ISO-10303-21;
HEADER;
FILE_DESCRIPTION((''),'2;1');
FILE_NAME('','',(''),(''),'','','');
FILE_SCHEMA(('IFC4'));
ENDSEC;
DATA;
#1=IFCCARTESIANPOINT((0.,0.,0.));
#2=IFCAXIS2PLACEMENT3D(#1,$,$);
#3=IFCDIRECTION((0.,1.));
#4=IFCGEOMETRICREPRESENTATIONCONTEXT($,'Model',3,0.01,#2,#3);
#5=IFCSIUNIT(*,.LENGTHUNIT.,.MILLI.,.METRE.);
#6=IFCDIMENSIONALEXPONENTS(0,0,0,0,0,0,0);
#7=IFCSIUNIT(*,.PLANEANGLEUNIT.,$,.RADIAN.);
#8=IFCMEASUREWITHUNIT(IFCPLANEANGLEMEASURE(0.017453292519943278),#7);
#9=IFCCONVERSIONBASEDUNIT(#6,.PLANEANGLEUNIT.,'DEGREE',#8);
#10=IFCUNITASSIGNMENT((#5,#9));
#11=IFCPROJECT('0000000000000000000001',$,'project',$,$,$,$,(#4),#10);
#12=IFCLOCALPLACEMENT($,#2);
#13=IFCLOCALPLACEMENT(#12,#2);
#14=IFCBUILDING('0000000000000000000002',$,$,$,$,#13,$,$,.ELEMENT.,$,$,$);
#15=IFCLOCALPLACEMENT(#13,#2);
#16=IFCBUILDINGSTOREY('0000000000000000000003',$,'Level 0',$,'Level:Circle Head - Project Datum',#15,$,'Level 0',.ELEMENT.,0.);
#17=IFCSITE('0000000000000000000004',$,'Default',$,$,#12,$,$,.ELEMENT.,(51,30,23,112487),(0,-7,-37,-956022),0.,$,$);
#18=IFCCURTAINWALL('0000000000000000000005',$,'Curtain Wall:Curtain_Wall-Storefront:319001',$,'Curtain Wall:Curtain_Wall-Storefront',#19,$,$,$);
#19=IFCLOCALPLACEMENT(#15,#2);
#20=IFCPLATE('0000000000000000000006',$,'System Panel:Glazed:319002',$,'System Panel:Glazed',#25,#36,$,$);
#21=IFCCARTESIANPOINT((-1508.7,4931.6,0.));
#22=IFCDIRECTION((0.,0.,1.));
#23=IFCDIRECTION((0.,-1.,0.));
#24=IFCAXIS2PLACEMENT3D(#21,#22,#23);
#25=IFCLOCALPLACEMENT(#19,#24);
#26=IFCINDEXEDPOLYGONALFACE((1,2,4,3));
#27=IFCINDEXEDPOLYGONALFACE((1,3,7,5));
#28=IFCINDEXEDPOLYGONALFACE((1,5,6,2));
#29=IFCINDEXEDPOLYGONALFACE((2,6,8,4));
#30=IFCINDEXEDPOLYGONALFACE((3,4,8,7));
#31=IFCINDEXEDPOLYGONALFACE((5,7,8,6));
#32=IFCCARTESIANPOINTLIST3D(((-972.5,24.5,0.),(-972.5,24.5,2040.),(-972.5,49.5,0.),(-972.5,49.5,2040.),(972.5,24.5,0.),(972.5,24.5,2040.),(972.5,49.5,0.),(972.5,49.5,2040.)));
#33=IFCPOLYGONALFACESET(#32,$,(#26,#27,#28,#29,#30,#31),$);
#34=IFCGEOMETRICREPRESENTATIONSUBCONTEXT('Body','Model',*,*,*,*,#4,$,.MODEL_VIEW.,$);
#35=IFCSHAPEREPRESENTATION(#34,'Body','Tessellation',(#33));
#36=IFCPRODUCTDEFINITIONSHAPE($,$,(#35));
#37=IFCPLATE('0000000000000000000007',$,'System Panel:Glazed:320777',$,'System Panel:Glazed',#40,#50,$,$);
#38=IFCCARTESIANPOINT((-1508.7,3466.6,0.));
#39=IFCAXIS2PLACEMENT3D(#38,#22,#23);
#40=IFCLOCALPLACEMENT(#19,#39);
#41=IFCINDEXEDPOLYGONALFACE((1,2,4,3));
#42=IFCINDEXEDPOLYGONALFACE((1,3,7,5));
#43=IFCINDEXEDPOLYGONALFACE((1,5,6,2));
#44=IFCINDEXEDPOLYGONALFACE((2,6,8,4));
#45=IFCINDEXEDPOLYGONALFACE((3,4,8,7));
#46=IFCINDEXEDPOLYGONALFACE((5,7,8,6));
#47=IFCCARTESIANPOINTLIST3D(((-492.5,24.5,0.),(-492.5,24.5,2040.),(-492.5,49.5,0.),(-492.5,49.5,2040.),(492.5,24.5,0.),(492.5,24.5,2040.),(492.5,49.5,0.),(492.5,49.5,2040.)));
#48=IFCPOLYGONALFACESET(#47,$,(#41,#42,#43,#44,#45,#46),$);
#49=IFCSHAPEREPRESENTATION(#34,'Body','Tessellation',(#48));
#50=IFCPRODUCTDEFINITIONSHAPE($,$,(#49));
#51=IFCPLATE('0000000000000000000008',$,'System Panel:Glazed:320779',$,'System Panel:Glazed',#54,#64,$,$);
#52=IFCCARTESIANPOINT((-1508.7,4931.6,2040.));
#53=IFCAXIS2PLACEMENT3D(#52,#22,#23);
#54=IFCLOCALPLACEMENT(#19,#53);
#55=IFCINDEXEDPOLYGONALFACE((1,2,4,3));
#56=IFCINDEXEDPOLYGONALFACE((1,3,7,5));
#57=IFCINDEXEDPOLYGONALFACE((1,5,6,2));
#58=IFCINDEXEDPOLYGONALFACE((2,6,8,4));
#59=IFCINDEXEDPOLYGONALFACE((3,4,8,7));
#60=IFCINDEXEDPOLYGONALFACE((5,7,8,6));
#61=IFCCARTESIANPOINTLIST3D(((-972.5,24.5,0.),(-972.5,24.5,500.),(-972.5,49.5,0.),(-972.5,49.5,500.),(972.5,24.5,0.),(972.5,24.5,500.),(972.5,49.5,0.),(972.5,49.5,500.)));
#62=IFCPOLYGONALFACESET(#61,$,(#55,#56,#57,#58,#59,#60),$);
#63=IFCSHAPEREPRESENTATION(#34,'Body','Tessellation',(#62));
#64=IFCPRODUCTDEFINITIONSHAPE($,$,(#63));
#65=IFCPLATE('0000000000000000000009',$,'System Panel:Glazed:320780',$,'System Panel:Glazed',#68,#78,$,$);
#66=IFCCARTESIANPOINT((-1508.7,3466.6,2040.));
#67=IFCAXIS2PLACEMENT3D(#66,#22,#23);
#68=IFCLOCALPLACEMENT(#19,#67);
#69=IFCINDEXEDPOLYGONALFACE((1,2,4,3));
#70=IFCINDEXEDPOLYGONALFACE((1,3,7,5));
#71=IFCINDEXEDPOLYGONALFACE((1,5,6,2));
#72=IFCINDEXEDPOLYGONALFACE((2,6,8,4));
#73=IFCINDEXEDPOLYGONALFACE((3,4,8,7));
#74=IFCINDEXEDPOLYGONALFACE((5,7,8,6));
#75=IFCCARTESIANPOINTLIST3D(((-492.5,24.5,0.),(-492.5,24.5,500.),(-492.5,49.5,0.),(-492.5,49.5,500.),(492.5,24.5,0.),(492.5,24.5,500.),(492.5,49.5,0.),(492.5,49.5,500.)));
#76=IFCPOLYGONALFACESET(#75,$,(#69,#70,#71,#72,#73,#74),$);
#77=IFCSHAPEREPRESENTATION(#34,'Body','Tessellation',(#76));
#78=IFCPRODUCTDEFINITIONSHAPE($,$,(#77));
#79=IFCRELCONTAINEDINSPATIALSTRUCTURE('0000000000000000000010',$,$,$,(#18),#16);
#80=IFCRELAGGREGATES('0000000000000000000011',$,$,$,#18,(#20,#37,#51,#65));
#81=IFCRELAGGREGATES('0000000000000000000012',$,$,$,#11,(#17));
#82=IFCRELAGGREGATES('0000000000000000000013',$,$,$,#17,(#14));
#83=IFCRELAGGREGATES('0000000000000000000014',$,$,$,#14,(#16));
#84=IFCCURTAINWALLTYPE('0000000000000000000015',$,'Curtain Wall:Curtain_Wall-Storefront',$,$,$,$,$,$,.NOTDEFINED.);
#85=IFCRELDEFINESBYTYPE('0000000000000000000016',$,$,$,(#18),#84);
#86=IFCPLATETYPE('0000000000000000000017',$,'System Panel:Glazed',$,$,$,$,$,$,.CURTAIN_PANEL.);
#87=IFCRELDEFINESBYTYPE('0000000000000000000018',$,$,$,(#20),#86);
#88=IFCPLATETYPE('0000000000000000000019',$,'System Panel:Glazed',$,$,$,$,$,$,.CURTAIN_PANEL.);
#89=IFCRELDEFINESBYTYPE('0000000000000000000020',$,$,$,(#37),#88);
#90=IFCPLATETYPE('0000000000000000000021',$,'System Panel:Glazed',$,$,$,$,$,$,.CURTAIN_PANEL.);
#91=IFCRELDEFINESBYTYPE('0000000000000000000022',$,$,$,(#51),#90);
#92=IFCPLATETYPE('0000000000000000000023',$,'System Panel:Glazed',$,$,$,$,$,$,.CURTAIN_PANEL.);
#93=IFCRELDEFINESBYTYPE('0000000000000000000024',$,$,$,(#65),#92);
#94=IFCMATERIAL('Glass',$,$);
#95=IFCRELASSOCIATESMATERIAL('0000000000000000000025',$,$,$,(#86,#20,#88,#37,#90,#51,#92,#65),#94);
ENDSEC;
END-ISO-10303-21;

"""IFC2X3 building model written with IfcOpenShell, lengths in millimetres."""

from ifc_helpers import new_model, entity, si_unit, converted_unit, direction, frame, origin, origin_2d_with_axis, place, context, subcontext, project, spatial, rectangle, extrude, source, transform, mapped, material, type_object, type_shapes, element, aggregate, save


model = new_model("IFC2X3")

# Units and contexts
model_context = context("Model", 3, precision=0.01, world=origin(), true_north=direction((0.0, 1.0)))
body_context = subcontext(model_context, "Body", "Model", "MODEL_VIEW")
ifc_project = project(units=[si_unit("LENGTHUNIT", "METRE", prefix="MILLI"), converted_unit("PLANEANGLEUNIT", "DEGREE", entity("IfcPlaneAngleMeasure", 0.017453292519943278), si_unit("PLANEANGLEUNIT", "RADIAN"), dimensions=[0, 0, 0, 0, 0, 0, 0])], contexts=[model_context])

# Site, building, storey
site_placement = place(None, origin())
site = spatial("IfcSite", under=ifc_project, at=site_placement, Name="Default", CompositionType="ELEMENT", RefLatitude=(51, 30, 23, 112487), RefLongitude=(0, -7, -37, -956022), RefElevation=0.0)
building_placement = place(site_placement, origin())
building = spatial("IfcBuilding", under=site, at=building_placement, CompositionType="ELEMENT")
storey_placement = place(building_placement, origin())
storey = spatial("IfcBuildingStorey", under=building, at=storey_placement, Name="Level 0", ObjectType="Level:Circle Head - Project Datum", LongName="Level 0", CompositionType="ELEMENT", Elevation=0.0)

# Curtain wall, plates
curtain_wall_type = type_object("IfcCurtainWallType", Name="Curtain Wall:Curtain_Wall-Storefront", PredefinedType="NOTDEFINED")
ifc_material_1 = material(Name="Glass")
curtain_wall_1_placement = place(storey_placement, origin())
curtain_wall_1 = element("IfcCurtainWall", 1, at=curtain_wall_1_placement, inside=storey, type_object=curtain_wall_type, Name="Curtain Wall:Curtain_Wall-Storefront:319001", ObjectType="Curtain Wall:Curtain_Wall-Storefront")
plate_type_1 = type_object("IfcPlateType", Name="System Panel:Glazed", PredefinedType="CURTAIN_PANEL", material=ifc_material_1)
shared_shape_1 = source(origin(), body_context, "Body", "SweptSolid", [
    extrude(rectangle(XDim=25.0, YDim=1945.0, at=origin_2d_with_axis()), frame((0.0, 37.0, 0.0), z_axis=(0.0, 0.0, 1.0), x_axis=(0.0, 1.0, 0.0)), (0.0, 0.0, 1.0), 2040.0),
])
type_shapes(plate_type_1, [shared_shape_1])
plate_1_placement = place(curtain_wall_1_placement, frame((-1508.7, 4931.6, 0.0), z_axis=(0.0, 0.0, 1.0), x_axis=(0.0, -1.0, 0.0)))
plate_1 = element("IfcPlate", 2, at=plate_1_placement, type_object=plate_type_1, material=ifc_material_1, Name="System Panel:Glazed:319002", ObjectType="System Panel:Glazed", context=body_context, shape_type="MappedRepresentation", body=[
    mapped(shared_shape_1, transform((0.0, 0.0, 0.0), scale=1.0)),
])
plate_type_2 = type_object("IfcPlateType", Name="System Panel:Glazed", PredefinedType="CURTAIN_PANEL", material=ifc_material_1)
shared_shape_2 = source(origin(), body_context, "Body", "SweptSolid", [
    extrude(rectangle(XDim=25.0, YDim=985.0, at=origin_2d_with_axis()), frame((0.0, 37.0, 0.0), z_axis=(0.0, 0.0, 1.0), x_axis=(0.0, 1.0, 0.0)), (0.0, 0.0, 1.0), 2040.0),
])
type_shapes(plate_type_2, [shared_shape_2])
plate_2_placement = place(curtain_wall_1_placement, frame((-1508.7, 3466.6, 0.0), z_axis=(0.0, 0.0, 1.0), x_axis=(0.0, -1.0, 0.0)))
plate_2 = element("IfcPlate", 3, at=plate_2_placement, type_object=plate_type_2, material=ifc_material_1, Name="System Panel:Glazed:320777", ObjectType="System Panel:Glazed", context=body_context, shape_type="MappedRepresentation", body=[
    mapped(shared_shape_2, transform((0.0, 0.0, 0.0), scale=1.0)),
])
plate_type_3 = type_object("IfcPlateType", Name="System Panel:Glazed", PredefinedType="CURTAIN_PANEL", material=ifc_material_1)
shared_shape_3 = source(origin(), body_context, "Body", "SweptSolid", [
    extrude(rectangle(XDim=25.0, YDim=1945.0, at=origin_2d_with_axis()), frame((0.0, 37.0, 0.0), z_axis=(0.0, 0.0, 1.0), x_axis=(0.0, 1.0, 0.0)), (0.0, 0.0, 1.0), 500.0),
])
type_shapes(plate_type_3, [shared_shape_3])
plate_3_placement = place(curtain_wall_1_placement, frame((-1508.7, 4931.6, 2040.0), z_axis=(0.0, 0.0, 1.0), x_axis=(0.0, -1.0, 0.0)))
plate_3 = element("IfcPlate", 4, at=plate_3_placement, type_object=plate_type_3, material=ifc_material_1, Name="System Panel:Glazed:320779", ObjectType="System Panel:Glazed", context=body_context, shape_type="MappedRepresentation", body=[
    mapped(shared_shape_3, transform((0.0, 0.0, 0.0), scale=1.0)),
])
plate_type_4 = type_object("IfcPlateType", Name="System Panel:Glazed", PredefinedType="CURTAIN_PANEL", material=ifc_material_1)
shared_shape_4 = source(origin(), body_context, "Body", "SweptSolid", [
    extrude(rectangle(XDim=25.0, YDim=985.0, at=origin_2d_with_axis()), frame((0.0, 37.0, 0.0), z_axis=(0.0, 0.0, 1.0), x_axis=(0.0, 1.0, 0.0)), (0.0, 0.0, 1.0), 500.0),
])
type_shapes(plate_type_4, [shared_shape_4])
plate_4_placement = place(curtain_wall_1_placement, frame((-1508.7, 3466.6, 2040.0), z_axis=(0.0, 0.0, 1.0), x_axis=(0.0, -1.0, 0.0)))
plate_4 = element("IfcPlate", 5, at=plate_4_placement, type_object=plate_type_4, material=ifc_material_1, Name="System Panel:Glazed:320780", ObjectType="System Panel:Glazed", context=body_context, shape_type="MappedRepresentation", body=[
    mapped(shared_shape_4, transform((0.0, 0.0, 0.0), scale=1.0)),
])
aggregate(curtain_wall_1, [plate_1, plate_2, plate_3, plate_4])

save(model, "model.ifc")
